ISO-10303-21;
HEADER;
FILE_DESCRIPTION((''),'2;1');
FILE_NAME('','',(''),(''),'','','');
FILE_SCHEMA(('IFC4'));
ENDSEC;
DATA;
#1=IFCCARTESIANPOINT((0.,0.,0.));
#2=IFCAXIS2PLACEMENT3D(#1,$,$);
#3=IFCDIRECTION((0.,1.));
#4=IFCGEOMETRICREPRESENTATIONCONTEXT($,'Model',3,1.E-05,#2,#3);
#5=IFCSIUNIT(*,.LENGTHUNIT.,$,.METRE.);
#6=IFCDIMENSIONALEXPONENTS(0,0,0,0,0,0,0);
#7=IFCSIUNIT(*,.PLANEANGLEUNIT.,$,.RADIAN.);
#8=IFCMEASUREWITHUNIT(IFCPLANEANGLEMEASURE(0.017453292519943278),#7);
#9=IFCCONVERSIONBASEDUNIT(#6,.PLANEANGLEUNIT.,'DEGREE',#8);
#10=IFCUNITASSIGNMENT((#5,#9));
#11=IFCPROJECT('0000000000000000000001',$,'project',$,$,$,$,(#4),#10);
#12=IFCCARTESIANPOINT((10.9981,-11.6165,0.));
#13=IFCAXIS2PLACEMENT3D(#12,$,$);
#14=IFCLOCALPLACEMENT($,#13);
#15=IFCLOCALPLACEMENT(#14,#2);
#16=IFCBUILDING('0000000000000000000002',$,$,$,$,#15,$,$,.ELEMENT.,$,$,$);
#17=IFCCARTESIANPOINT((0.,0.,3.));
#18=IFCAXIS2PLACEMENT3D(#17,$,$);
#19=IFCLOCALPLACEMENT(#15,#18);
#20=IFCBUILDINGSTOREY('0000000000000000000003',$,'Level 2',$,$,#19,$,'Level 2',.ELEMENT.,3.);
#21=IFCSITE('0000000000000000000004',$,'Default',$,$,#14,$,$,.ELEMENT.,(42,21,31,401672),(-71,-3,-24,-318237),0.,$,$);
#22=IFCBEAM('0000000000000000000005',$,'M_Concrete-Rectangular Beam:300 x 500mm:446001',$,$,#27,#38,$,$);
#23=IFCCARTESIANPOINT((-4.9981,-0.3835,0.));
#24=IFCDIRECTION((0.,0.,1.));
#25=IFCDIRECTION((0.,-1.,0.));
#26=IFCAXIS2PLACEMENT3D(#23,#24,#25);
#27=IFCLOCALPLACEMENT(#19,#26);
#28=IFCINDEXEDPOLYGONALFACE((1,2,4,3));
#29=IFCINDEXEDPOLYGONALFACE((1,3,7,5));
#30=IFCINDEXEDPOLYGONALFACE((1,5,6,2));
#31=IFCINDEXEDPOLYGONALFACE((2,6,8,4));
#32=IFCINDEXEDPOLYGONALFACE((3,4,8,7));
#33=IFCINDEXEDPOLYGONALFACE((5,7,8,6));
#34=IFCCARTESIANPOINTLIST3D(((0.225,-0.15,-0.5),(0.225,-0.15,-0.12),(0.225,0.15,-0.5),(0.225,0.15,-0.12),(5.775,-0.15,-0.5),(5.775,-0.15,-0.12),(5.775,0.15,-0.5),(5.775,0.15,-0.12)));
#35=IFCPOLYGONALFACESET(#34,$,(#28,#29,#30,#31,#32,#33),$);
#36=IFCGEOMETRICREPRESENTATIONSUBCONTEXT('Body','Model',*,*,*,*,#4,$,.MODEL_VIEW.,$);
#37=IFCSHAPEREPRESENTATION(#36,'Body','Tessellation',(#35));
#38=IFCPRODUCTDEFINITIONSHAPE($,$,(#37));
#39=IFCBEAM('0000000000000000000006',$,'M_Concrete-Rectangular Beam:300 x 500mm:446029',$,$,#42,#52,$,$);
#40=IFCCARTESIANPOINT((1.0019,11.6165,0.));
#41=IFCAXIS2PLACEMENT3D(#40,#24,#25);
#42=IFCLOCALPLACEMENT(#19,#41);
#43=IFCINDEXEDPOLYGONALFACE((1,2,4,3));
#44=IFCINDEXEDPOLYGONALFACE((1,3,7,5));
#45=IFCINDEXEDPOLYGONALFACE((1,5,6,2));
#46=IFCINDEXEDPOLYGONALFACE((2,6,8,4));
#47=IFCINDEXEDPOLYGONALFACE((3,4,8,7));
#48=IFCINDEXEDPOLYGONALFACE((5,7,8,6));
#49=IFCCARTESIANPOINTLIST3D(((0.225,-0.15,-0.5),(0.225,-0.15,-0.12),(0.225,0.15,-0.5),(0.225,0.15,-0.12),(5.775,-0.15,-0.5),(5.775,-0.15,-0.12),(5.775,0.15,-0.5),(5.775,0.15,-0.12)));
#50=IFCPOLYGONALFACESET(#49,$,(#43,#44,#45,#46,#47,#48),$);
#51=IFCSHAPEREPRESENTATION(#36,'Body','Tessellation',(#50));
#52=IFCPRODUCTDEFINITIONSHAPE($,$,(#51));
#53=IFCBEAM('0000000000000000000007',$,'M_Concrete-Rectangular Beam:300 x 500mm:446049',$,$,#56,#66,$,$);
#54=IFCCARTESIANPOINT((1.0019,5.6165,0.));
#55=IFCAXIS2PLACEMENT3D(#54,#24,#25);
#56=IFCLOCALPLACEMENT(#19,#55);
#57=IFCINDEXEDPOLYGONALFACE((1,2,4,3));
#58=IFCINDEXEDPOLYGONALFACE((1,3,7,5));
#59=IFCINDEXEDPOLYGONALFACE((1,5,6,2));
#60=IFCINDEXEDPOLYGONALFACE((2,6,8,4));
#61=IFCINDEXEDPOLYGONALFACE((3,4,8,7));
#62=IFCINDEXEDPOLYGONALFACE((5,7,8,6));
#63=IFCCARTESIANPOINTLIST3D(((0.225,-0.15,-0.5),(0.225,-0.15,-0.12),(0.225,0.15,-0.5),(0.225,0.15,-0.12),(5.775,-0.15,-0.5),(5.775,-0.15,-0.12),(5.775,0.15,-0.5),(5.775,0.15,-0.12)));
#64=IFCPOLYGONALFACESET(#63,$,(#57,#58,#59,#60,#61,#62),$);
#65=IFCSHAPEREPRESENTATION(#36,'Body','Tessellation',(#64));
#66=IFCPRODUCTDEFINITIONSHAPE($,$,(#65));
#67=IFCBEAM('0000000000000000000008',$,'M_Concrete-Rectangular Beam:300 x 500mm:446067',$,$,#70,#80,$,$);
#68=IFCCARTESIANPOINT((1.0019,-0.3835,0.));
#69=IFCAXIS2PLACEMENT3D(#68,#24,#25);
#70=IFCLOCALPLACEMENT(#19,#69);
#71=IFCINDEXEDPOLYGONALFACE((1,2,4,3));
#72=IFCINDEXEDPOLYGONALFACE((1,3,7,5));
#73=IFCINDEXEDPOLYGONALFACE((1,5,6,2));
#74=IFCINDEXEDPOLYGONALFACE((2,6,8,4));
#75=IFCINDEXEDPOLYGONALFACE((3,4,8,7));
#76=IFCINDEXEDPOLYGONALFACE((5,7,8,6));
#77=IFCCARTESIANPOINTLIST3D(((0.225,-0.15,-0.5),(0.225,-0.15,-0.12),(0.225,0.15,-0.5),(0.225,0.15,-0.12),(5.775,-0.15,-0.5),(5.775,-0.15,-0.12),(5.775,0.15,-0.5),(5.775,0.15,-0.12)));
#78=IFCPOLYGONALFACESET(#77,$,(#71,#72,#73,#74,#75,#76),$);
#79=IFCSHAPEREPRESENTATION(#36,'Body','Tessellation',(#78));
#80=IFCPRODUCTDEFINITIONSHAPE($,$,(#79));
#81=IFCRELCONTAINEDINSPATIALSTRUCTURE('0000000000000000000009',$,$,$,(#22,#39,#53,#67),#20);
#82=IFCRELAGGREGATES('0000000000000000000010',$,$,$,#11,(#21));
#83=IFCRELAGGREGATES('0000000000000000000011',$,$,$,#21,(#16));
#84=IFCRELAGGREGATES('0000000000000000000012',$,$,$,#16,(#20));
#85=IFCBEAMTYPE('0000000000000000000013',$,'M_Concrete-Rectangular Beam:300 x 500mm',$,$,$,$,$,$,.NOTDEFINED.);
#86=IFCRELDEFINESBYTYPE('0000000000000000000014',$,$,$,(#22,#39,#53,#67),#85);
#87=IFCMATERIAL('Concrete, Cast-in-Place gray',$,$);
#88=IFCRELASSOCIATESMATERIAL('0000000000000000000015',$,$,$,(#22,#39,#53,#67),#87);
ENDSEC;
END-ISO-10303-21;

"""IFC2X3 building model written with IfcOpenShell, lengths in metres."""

from ifc_helpers import new_model, entity, si_unit, converted_unit, direction, frame, frame_2d, origin, place, context, subcontext, project, spatial, rectangle, extrude, material, type_object, element, save


model = new_model("IFC2X3")

# Units and contexts
model_context = context("Model", 3, precision=1e-05, world=origin(), true_north=direction((0.0, 1.0)))
body_context = subcontext(model_context, "Body", "Model", "MODEL_VIEW")
ifc_project = project(units=[si_unit("LENGTHUNIT", "METRE"), converted_unit("PLANEANGLEUNIT", "DEGREE", entity("IfcPlaneAngleMeasure", 0.017453292519943278), si_unit("PLANEANGLEUNIT", "RADIAN"), dimensions=[0, 0, 0, 0, 0, 0, 0])], contexts=[model_context])

# Site, building, storey
site_placement = place(None, frame((10.9981, -11.6165, 0.0)))
site = spatial("IfcSite", under=ifc_project, at=site_placement, Name="Default", CompositionType="ELEMENT", RefLatitude=(42, 21, 31, 401672), RefLongitude=(-71, -3, -24, -318237), RefElevation=0.0)
building_placement = place(site_placement, origin())
building = spatial("IfcBuilding", under=site, at=building_placement, CompositionType="ELEMENT")
storey_placement = place(building_placement, frame((0.0, 0.0, 3.0)))
storey = spatial("IfcBuildingStorey", under=building, at=storey_placement, Name="Level 2", LongName="Level 2", CompositionType="ELEMENT", Elevation=3.0)

# Shared definitions
ifc_material_1 = material(Name="Concrete, Cast-in-Place gray")

# Beams
beam_type = type_object("IfcBeamType", Name="M_Concrete-Rectangular Beam:300 x 500mm", PredefinedType="NOTDEFINED")
beam_1_placement = place(storey_placement, frame((-4.9981, -0.3835, 0.0), z_axis=(0.0, 0.0, 1.0), x_axis=(0.0, -1.0, 0.0)))
element("IfcBeam", 1, at=beam_1_placement, inside=storey, type_object=beam_type, material=ifc_material_1, Name="M_Concrete-Rectangular Beam:300 x 500mm:446001", context=body_context, shape_type="SweptSolid", body=[
    extrude(rectangle(XDim=0.38, YDim=0.3, at=frame_2d((0.0, 0.0), x_axis=(1.0, 0.0))), frame((0.225, 0.0, -0.31), z_axis=(1.0, 0.0, 0.0), x_axis=(0.0, 0.0, -1.0)), (0.0, 0.0, 1.0), 5.55),
])
beam_2_placement = place(storey_placement, frame((1.0019, 11.6165, 0.0), z_axis=(0.0, 0.0, 1.0), x_axis=(0.0, -1.0, 0.0)))
element("IfcBeam", 2, at=beam_2_placement, inside=storey, type_object=beam_type, material=ifc_material_1, Name="M_Concrete-Rectangular Beam:300 x 500mm:446029", context=body_context, shape_type="SweptSolid", body=[
    extrude(rectangle(XDim=0.38, YDim=0.3, at=frame_2d((0.0, 0.0), x_axis=(1.0, 0.0))), frame((0.225, 0.0, -0.31), z_axis=(1.0, 0.0, 0.0), x_axis=(0.0, 0.0, -1.0)), (0.0, 0.0, 1.0), 5.55),
])
beam_3_placement = place(storey_placement, frame((1.0019, 5.6165, 0.0), z_axis=(0.0, 0.0, 1.0), x_axis=(0.0, -1.0, 0.0)))
element("IfcBeam", 3, at=beam_3_placement, inside=storey, type_object=beam_type, material=ifc_material_1, Name="M_Concrete-Rectangular Beam:300 x 500mm:446049", context=body_context, shape_type="SweptSolid", body=[
    extrude(rectangle(XDim=0.38, YDim=0.3, at=frame_2d((0.0, 0.0), x_axis=(1.0, 0.0))), frame((0.225, 0.0, -0.31), z_axis=(1.0, 0.0, 0.0), x_axis=(0.0, 0.0, -1.0)), (0.0, 0.0, 1.0), 5.55),
])
beam_4_placement = place(storey_placement, frame((1.0019, -0.3835, 0.0), z_axis=(0.0, 0.0, 1.0), x_axis=(0.0, -1.0, 0.0)))
element("IfcBeam", 4, at=beam_4_placement, inside=storey, type_object=beam_type, material=ifc_material_1, Name="M_Concrete-Rectangular Beam:300 x 500mm:446067", context=body_context, shape_type="SweptSolid", body=[
    extrude(rectangle(XDim=0.38, YDim=0.3, at=frame_2d((0.0, 0.0), x_axis=(1.0, 0.0))), frame((0.225, 0.0, -0.31), z_axis=(1.0, 0.0, 0.0), x_axis=(0.0, 0.0, -1.0)), (0.0, 0.0, 1.0), 5.55),
])

save(model, "model.ifc")
